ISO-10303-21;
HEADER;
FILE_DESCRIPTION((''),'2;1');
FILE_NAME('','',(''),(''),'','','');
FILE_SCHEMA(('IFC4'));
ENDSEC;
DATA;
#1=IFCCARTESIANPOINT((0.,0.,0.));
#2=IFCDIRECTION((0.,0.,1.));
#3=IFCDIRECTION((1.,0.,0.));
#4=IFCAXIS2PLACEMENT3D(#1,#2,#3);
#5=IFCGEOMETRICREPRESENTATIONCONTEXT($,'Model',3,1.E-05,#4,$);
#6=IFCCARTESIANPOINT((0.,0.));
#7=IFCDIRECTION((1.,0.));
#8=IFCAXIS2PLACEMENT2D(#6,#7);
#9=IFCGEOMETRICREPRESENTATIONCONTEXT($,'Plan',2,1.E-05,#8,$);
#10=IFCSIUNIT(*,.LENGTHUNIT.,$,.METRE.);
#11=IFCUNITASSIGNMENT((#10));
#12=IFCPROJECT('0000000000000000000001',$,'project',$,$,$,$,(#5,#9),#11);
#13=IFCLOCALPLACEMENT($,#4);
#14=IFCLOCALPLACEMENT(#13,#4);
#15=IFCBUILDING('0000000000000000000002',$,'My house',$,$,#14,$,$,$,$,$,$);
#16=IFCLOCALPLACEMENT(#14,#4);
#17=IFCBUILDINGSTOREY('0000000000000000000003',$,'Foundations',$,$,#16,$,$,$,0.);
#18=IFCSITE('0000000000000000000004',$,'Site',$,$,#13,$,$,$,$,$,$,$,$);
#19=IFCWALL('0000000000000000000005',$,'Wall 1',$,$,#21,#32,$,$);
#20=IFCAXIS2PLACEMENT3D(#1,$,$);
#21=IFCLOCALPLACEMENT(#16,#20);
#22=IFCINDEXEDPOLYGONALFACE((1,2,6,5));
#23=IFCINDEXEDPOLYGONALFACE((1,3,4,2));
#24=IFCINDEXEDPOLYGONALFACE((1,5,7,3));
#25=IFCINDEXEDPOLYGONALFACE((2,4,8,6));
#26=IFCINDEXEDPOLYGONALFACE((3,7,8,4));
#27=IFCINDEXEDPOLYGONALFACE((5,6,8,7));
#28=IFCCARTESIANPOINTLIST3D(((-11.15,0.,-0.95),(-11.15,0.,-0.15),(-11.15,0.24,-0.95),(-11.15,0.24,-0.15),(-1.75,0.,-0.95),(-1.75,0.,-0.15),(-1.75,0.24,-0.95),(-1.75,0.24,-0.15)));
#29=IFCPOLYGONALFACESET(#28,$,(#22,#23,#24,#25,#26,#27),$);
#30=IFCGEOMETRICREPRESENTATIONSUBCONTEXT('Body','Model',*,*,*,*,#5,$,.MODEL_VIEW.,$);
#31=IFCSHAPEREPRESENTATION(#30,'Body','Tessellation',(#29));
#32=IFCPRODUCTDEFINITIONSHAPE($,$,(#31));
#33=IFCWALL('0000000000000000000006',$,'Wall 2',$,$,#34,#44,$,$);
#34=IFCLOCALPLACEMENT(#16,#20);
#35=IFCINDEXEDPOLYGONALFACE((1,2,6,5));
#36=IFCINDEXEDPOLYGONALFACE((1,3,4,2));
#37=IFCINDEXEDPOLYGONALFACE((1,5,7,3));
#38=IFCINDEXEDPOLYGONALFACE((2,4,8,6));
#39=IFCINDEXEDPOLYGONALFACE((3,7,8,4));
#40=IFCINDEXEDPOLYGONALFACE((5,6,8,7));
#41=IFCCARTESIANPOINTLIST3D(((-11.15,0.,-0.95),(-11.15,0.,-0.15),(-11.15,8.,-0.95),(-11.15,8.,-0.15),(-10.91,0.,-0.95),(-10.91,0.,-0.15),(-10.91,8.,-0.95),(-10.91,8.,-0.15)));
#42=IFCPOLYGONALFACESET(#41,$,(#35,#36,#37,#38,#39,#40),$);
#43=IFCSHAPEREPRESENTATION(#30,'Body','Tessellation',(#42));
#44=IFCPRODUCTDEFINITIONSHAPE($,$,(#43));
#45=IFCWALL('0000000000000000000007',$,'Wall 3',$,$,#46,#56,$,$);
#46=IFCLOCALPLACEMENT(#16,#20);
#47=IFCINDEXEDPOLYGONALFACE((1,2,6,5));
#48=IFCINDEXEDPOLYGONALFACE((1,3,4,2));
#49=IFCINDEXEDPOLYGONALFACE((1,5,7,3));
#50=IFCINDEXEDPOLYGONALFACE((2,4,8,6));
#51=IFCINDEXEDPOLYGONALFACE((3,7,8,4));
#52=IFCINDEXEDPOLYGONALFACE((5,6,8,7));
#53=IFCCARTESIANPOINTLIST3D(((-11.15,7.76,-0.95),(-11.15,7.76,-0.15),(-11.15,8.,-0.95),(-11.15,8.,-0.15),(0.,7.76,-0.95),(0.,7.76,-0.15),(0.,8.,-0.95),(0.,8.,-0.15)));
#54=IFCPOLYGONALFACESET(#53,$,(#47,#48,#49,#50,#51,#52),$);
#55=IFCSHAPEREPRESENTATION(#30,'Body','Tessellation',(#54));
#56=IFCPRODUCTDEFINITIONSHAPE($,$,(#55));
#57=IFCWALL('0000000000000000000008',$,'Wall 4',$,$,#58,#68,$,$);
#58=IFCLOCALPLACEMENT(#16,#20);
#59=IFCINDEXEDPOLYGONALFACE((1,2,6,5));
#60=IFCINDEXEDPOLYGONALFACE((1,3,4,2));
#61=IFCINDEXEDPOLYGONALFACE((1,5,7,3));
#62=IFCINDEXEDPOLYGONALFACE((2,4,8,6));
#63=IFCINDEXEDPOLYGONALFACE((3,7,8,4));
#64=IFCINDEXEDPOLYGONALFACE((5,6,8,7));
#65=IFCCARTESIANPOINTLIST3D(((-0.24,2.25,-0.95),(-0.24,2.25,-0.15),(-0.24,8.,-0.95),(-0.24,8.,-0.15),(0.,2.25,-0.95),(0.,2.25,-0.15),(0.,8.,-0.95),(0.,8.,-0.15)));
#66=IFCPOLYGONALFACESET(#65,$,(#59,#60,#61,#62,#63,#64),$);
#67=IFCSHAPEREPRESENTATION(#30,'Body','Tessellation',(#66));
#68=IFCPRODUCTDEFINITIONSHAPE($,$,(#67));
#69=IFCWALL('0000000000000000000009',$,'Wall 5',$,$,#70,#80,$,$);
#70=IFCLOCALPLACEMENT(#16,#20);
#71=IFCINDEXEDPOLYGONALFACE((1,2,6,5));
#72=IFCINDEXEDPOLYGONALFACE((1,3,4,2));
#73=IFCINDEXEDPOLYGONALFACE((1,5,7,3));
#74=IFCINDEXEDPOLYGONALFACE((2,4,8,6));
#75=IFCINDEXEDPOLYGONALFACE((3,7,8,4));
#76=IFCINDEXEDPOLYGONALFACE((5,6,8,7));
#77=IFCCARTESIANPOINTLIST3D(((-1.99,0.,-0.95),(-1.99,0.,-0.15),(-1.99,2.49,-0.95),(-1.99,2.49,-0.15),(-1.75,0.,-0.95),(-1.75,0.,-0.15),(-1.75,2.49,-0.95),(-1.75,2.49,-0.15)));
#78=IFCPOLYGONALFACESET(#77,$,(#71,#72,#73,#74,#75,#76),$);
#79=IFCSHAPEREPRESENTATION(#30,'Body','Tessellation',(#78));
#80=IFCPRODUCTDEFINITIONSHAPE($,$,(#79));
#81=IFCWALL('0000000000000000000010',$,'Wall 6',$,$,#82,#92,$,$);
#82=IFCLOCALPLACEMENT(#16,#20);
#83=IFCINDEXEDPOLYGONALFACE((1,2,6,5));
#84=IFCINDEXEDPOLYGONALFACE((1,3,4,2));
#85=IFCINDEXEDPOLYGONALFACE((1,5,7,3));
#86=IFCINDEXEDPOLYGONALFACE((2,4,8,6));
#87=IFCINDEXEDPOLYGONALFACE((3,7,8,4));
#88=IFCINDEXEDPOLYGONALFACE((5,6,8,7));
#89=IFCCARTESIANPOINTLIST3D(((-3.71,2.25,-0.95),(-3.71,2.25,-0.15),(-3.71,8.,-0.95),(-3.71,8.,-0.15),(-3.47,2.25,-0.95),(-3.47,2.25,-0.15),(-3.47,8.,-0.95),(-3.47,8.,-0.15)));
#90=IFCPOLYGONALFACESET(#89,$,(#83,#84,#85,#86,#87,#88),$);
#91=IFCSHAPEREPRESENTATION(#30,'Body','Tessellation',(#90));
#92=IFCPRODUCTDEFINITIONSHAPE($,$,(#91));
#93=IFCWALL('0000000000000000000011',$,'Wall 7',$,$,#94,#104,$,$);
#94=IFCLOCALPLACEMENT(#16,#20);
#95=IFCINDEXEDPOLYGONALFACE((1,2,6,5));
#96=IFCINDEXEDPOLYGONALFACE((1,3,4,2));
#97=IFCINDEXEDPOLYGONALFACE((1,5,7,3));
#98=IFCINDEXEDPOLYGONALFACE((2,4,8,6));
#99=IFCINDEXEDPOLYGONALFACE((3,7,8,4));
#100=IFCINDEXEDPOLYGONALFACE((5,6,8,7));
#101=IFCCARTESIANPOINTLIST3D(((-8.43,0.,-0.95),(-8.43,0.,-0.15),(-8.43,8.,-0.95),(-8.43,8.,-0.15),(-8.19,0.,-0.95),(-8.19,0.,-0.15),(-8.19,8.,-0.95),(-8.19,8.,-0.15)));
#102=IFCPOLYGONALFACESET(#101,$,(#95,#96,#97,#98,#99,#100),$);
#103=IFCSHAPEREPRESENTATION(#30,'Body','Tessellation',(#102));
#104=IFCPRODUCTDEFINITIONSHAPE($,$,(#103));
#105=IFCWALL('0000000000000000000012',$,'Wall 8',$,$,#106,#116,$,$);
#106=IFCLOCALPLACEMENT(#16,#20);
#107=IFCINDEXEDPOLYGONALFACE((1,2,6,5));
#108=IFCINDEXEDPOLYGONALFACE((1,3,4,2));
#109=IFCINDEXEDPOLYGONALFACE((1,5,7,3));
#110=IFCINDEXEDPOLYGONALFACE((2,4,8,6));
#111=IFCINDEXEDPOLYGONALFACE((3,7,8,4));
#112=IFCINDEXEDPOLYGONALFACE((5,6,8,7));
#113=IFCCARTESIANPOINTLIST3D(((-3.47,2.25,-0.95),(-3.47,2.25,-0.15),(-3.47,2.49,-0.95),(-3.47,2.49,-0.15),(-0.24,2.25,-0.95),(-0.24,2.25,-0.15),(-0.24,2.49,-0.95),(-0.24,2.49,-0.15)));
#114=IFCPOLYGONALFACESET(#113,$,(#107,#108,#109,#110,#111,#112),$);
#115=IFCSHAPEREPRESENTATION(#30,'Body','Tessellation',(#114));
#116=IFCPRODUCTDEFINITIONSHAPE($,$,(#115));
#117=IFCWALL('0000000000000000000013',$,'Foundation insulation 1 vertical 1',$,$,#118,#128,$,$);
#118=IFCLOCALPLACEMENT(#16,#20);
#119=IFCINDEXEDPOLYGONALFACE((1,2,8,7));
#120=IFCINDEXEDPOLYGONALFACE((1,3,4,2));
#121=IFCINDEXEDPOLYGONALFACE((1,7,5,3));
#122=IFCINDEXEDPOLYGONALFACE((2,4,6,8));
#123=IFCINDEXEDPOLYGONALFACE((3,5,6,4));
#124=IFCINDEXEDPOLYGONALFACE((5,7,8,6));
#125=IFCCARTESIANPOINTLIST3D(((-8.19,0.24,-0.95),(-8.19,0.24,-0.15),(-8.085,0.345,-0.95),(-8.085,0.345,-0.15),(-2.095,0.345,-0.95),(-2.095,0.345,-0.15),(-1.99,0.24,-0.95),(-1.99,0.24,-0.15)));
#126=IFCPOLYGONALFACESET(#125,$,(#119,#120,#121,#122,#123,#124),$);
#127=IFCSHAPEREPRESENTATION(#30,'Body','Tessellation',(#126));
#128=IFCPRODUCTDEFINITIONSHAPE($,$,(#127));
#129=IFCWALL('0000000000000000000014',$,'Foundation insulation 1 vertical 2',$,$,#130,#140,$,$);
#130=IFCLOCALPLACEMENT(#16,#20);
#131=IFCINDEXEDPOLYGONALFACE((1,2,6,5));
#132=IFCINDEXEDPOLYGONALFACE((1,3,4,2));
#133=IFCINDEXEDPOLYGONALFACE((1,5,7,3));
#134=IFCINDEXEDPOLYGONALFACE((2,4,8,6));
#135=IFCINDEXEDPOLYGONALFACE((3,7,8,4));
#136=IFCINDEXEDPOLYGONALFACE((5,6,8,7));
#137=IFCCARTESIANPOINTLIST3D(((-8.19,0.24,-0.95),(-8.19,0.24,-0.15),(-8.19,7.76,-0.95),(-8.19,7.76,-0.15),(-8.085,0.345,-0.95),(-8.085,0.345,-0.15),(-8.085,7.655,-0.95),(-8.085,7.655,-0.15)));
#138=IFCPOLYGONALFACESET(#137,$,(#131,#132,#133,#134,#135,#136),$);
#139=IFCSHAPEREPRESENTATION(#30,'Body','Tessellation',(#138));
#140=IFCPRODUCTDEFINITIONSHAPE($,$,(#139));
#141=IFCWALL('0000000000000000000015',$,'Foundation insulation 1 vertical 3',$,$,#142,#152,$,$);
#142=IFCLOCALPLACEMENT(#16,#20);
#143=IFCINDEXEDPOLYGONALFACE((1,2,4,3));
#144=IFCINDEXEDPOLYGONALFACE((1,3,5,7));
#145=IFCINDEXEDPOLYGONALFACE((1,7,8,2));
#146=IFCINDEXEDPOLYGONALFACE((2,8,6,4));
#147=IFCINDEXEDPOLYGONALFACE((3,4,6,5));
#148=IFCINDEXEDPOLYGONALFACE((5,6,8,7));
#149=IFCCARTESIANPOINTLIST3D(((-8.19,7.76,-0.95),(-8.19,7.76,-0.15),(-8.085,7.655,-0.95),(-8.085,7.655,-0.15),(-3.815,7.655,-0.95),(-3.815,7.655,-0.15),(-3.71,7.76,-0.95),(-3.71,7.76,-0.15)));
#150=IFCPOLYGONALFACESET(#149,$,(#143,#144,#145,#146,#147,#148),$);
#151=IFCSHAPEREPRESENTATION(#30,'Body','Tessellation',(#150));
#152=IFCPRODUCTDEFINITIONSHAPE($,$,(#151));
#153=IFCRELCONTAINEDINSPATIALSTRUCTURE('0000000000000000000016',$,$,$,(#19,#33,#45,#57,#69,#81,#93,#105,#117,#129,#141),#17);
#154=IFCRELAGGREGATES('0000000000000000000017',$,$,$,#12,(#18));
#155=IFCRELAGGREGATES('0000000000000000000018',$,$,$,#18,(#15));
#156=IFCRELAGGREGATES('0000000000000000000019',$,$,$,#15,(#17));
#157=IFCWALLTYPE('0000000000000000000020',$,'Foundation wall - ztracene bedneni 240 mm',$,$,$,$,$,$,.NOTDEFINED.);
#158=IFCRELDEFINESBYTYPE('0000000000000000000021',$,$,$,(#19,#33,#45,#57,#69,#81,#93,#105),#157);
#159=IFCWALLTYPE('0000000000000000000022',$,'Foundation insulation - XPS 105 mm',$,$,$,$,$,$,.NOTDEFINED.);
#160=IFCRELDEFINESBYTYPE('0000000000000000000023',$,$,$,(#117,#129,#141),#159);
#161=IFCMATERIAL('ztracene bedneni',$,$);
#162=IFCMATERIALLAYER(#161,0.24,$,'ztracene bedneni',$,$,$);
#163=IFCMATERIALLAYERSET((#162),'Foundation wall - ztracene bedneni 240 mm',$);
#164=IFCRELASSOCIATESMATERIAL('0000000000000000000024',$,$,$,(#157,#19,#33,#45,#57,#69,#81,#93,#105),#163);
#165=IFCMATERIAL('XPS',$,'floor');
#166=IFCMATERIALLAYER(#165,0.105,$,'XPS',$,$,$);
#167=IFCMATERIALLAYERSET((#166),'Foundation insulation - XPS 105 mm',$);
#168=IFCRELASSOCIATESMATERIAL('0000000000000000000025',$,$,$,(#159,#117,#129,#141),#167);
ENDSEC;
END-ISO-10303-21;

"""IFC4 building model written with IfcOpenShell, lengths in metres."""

from ifc_helpers import new_model, si_unit, frame, origin_with_axes, origin_2d_with_axis, place, context, subcontext, project, spatial, line, indexed_curve, outline, extrude, source, transform, mapped, material, layer, layer_set, layer_usage, type_object, element, save


model = new_model("IFC4")

# Units and contexts
model_context = context("Model", 3, precision=1e-05, world=origin_with_axes())
plan_context = context("Plan", 2, precision=1e-05, world=origin_2d_with_axis())
body_context = subcontext(model_context, "Body", "Model", "MODEL_VIEW")
ifc_project = project(units=[si_unit("LENGTHUNIT", "METRE")], contexts=[model_context, plan_context])

# Site, building, storey
site_placement = place(None, origin_with_axes())
site = spatial("IfcSite", under=ifc_project, at=site_placement, Name="Site")
building_placement = place(site_placement, origin_with_axes())
building = spatial("IfcBuilding", under=site, at=building_placement, Name="My house")
storey_placement = place(building_placement, origin_with_axes())
storey = spatial("IfcBuildingStorey", under=building, at=storey_placement, Name="Foundations", Elevation=0.0)

# Shared definitions
ifc_material_1 = material(Name="XPS", Category="floor")

# Walls
ifc_material_2 = material(Name="ztracene bedneni")
ifc_layer_1 = layer(ifc_material_2, 0.24, Name="ztracene bedneni")
ifc_layer_set_1 = layer_set([ifc_layer_1], Name="Foundation wall - ztracene bedneni 240 mm")
ifc_layer_usage_1 = layer_usage(ifc_layer_set_1, "AXIS2", "NEGATIVE", 0.24)
wall_type_1 = type_object("IfcWallType", Name="Foundation wall - ztracene bedneni 240 mm", PredefinedType="NOTDEFINED", material=ifc_layer_set_1)
shared_shape_1 = source(origin_with_axes(), body_context, "Body", "SweptSolid", [
    extrude(outline(indexed_curve([(0.0, 0.0), (0.0, 0.24), (9.4, 0.24), (9.4, 0.0), (0.0, 0.0)], self_intersect=False)), origin_with_axes(), (0.0, 0.0, 1.0), 0.8),
])
wall_1_placement = place(storey_placement, frame((-1.75, 0.0, -0.95), z_axis=(0.0, 0.0, 1.0), x_axis=(1.0, 0.0, 0.0)))
element("IfcWall", 1, at=wall_1_placement, inside=storey, type_object=wall_type_1, material=ifc_layer_usage_1, Name="Wall 1", context=body_context, shape_type="MappedRepresentation", body=[
    mapped(shared_shape_1, transform((0.0, 0.0, 0.0), x_axis=(-1.0, 0.0, 0.0), y_axis=(0.0, 1.0, 0.0), z_axis=(0.0, 0.0, 1.0), scale=1.0)),
])
ifc_layer_usage_2 = layer_usage(ifc_layer_set_1, "AXIS2", "NEGATIVE", 0.24)
shared_shape_2 = source(origin_with_axes(), body_context, "Body", "SweptSolid", [
    extrude(outline(indexed_curve([(0.0, 0.0), (0.0, 0.24), (8.0, 0.24), (8.0, 0.0), (0.0, 0.0)], self_intersect=False)), origin_with_axes(), (0.0, 0.0, 1.0), 0.8),
])
wall_2_placement = place(storey_placement, frame((-11.15, 0.0, -0.95), z_axis=(0.0, 0.0, 1.0), x_axis=(0.0, -1.0, 0.0)))
element("IfcWall", 2, at=wall_2_placement, inside=storey, type_object=wall_type_1, material=ifc_layer_usage_2, Name="Wall 2", context=body_context, shape_type="MappedRepresentation", body=[
    mapped(shared_shape_2, transform((0.0, 0.0, 0.0), x_axis=(-1.0, 0.0, 0.0), y_axis=(0.0, 1.0, 0.0), z_axis=(0.0, 0.0, 1.0), scale=1.0)),
])
ifc_layer_usage_3 = layer_usage(ifc_layer_set_1, "AXIS2", "NEGATIVE", 0.24)
shared_shape_3 = source(origin_with_axes(), body_context, "Body", "SweptSolid", [
    extrude(outline(indexed_curve([(0.0, 0.0), (0.0, 0.24), (11.15, 0.24), (11.15, 0.0), (0.0, 0.0)], self_intersect=False)), origin_with_axes(), (0.0, 0.0, 1.0), 0.8),
])
wall_3_placement = place(storey_placement, frame((-11.15, 8.0, -0.95), z_axis=(0.0, 0.0, 1.0), x_axis=(-1.0, 0.0, 0.0)))
element("IfcWall", 3, at=wall_3_placement, inside=storey, type_object=wall_type_1, material=ifc_layer_usage_3, Name="Wall 3", context=body_context, shape_type="MappedRepresentation", body=[
    mapped(shared_shape_3, transform((0.0, 0.0, 0.0), x_axis=(-1.0, 0.0, 0.0), y_axis=(0.0, 1.0, 0.0), z_axis=(0.0, 0.0, 1.0), scale=1.0)),
])
ifc_layer_usage_4 = layer_usage(ifc_layer_set_1, "AXIS2", "NEGATIVE", 0.24)
shared_shape_4 = source(origin_with_axes(), body_context, "Body", "SweptSolid", [
    extrude(outline(indexed_curve([(0.0, 0.0), (0.0, 0.24), (5.75, 0.24), (5.75, 0.0), (0.0, 0.0)], self_intersect=False)), origin_with_axes(), (0.0, 0.0, 1.0), 0.8),
])
wall_4_placement = place(storey_placement, frame((0.0, 8.0, -0.95), z_axis=(0.0, 0.0, 1.0), x_axis=(0.0, 1.0, 0.0)))
element("IfcWall", 4, at=wall_4_placement, inside=storey, type_object=wall_type_1, material=ifc_layer_usage_4, Name="Wall 4", context=body_context, shape_type="MappedRepresentation", body=[
    mapped(shared_shape_4, transform((0.0, 0.0, 0.0), x_axis=(-1.0, 0.0, 0.0), y_axis=(0.0, 1.0, 0.0), z_axis=(0.0, 0.0, 1.0), scale=1.0)),
])
ifc_layer_usage_5 = layer_usage(ifc_layer_set_1, "AXIS2", "NEGATIVE", 0.24)
shared_shape_5 = source(origin_with_axes(), body_context, "Body", "SweptSolid", [
    extrude(outline(indexed_curve([(0.0, 0.0), (0.0, 0.24), (2.49, 0.24), (2.49, 0.0), (0.0, 0.0)], self_intersect=False)), origin_with_axes(), (0.0, 0.0, 1.0), 0.8),
])
wall_5_placement = place(storey_placement, frame((-1.75, 2.49, -0.95), z_axis=(0.0, 0.0, 1.0), x_axis=(0.0, 1.0, 0.0)))
element("IfcWall", 5, at=wall_5_placement, inside=storey, type_object=wall_type_1, material=ifc_layer_usage_5, Name="Wall 5", context=body_context, shape_type="MappedRepresentation", body=[
    mapped(shared_shape_5, transform((0.0, 0.0, 0.0), x_axis=(-1.0, 0.0, 0.0), y_axis=(0.0, 1.0, 0.0), z_axis=(0.0, 0.0, 1.0), scale=1.0)),
])
ifc_layer_usage_6 = layer_usage(ifc_layer_set_1, "AXIS2", "NEGATIVE", 0.24)
shared_shape_6 = source(origin_with_axes(), body_context, "Body", "SweptSolid", [
    extrude(outline(indexed_curve([(0.0, 0.0), (0.0, 0.24), (5.75, 0.24), (5.75, 0.0), (0.0, 0.0)], self_intersect=False)), origin_with_axes(), (0.0, 0.0, 1.0), 0.8),
])
wall_6_placement = place(storey_placement, frame((-3.71, 2.25, -0.95), z_axis=(0.0, 0.0, 1.0), x_axis=(0.0, -1.0, 0.0)))
element("IfcWall", 6, at=wall_6_placement, inside=storey, type_object=wall_type_1, material=ifc_layer_usage_6, Name="Wall 6", context=body_context, shape_type="MappedRepresentation", body=[
    mapped(shared_shape_6, transform((0.0, 0.0, 0.0), x_axis=(-1.0, 0.0, 0.0), y_axis=(0.0, 1.0, 0.0), z_axis=(0.0, 0.0, 1.0), scale=1.0)),
])
ifc_layer_usage_7 = layer_usage(ifc_layer_set_1, "AXIS2", "NEGATIVE", 0.24)
shared_shape_7 = source(origin_with_axes(), body_context, "Body", "SweptSolid", [
    extrude(outline(indexed_curve([(0.0, 0.0), (0.0, 0.24), (8.0, 0.24), (8.0, 0.0), (0.0, 0.0)], self_intersect=False)), origin_with_axes(), (0.0, 0.0, 1.0), 0.8),
])
wall_7_placement = place(storey_placement, frame((-8.43, 0.0, -0.95), z_axis=(0.0, 0.0, 1.0), x_axis=(0.0, -1.0, 0.0)))
element("IfcWall", 7, at=wall_7_placement, inside=storey, type_object=wall_type_1, material=ifc_layer_usage_7, Name="Wall 7", context=body_context, shape_type="MappedRepresentation", body=[
    mapped(shared_shape_7, transform((0.0, 0.0, 0.0), x_axis=(-1.0, 0.0, 0.0), y_axis=(0.0, 1.0, 0.0), z_axis=(0.0, 0.0, 1.0), scale=1.0)),
])
ifc_layer_usage_8 = layer_usage(ifc_layer_set_1, "AXIS2", "NEGATIVE", 0.24)
shared_shape_8 = source(origin_with_axes(), body_context, "Body", "SweptSolid", [
    extrude(outline(indexed_curve([(0.0, 0.0), (0.0, 0.24), (3.23, 0.24), (3.23, 0.0), (0.0, 0.0)], self_intersect=False)), origin_with_axes(), (0.0, 0.0, 1.0), 0.8),
])
wall_8_placement = place(storey_placement, frame((-0.24, 2.25, -0.95), z_axis=(0.0, 0.0, 1.0), x_axis=(1.0, 0.0, 0.0)))
element("IfcWall", 8, at=wall_8_placement, inside=storey, type_object=wall_type_1, material=ifc_layer_usage_8, Name="Wall 8", context=body_context, shape_type="MappedRepresentation", body=[
    mapped(shared_shape_8, transform((0.0, 0.0, 0.0), x_axis=(-1.0, 0.0, 0.0), y_axis=(0.0, 1.0, 0.0), z_axis=(0.0, 0.0, 1.0), scale=1.0)),
])
ifc_layer_2 = layer(ifc_material_1, 0.105, Name="XPS")
ifc_layer_set_2 = layer_set([ifc_layer_2], Name="Foundation insulation - XPS 105 mm")
ifc_layer_usage_9 = layer_usage(ifc_layer_set_2, "AXIS2", "NEGATIVE", 0.105)
wall_type_2 = type_object("IfcWallType", Name="Foundation insulation - XPS 105 mm", PredefinedType="NOTDEFINED", material=ifc_layer_set_2)
shared_shape_9 = source(origin_with_axes(), body_context, "Body", "SweptSolid", [
    extrude(outline(indexed_curve([(0.0, 0.0), (0.105, 0.105), (6.095, 0.105), (6.2, 0.0)], segments=[line(1, 2, 3, 4, 1)])), origin_with_axes(), (0.0, 0.0, 1.0), 0.8),
])
wall_9_placement = place(storey_placement, frame((-1.99, 0.24, -0.95), z_axis=(0.0, 0.0, 1.0), x_axis=(1.0, 0.0, 0.0)))
element("IfcWall", 9, at=wall_9_placement, inside=storey, type_object=wall_type_2, material=ifc_layer_usage_9, Name="Foundation insulation 1 vertical 1", context=body_context, shape_type="MappedRepresentation", body=[
    mapped(shared_shape_9, transform((0.0, 0.0, 0.0), x_axis=(-1.0, 0.0, 0.0), y_axis=(0.0, 1.0, 0.0), z_axis=(0.0, 0.0, 1.0), scale=1.0)),
])
ifc_layer_usage_10 = layer_usage(ifc_layer_set_2, "AXIS2", "NEGATIVE", 0.105)
shared_shape_10 = source(origin_with_axes(), body_context, "Body", "SweptSolid", [
    extrude(outline(indexed_curve([(0.0, 0.0), (0.105, 0.105), (7.415, 0.105), (7.52, 0.0)], segments=[line(1, 2, 3, 4, 1)])), origin_with_axes(), (0.0, 0.0, 1.0), 0.8),
])
wall_10_placement = place(storey_placement, frame((-8.19, 0.24, -0.95), z_axis=(0.0, 0.0, 1.0), x_axis=(0.0, -1.0, 0.0)))
element("IfcWall", 10, at=wall_10_placement, inside=storey, type_object=wall_type_2, material=ifc_layer_usage_10, Name="Foundation insulation 1 vertical 2", context=body_context, shape_type="MappedRepresentation", body=[
    mapped(shared_shape_10, transform((0.0, 0.0, 0.0), x_axis=(-1.0, 0.0, 0.0), y_axis=(0.0, 1.0, 0.0), z_axis=(0.0, 0.0, 1.0), scale=1.0)),
])
ifc_layer_usage_11 = layer_usage(ifc_layer_set_2, "AXIS2", "NEGATIVE", 0.105)
shared_shape_11 = source(origin_with_axes(), body_context, "Body", "SweptSolid", [
    extrude(outline(indexed_curve([(0.0, 0.0), (0.105, 0.105), (4.375, 0.105), (4.48, 0.0)], segments=[line(1, 2, 3, 4, 1)])), origin_with_axes(), (0.0, 0.0, 1.0), 0.8),
])
wall_11_placement = place(storey_placement, frame((-8.19, 7.76, -0.95), z_axis=(0.0, 0.0, 1.0), x_axis=(-1.0, 0.0, 0.0)))
element("IfcWall", 11, at=wall_11_placement, inside=storey, type_object=wall_type_2, material=ifc_layer_usage_11, Name="Foundation insulation 1 vertical 3", context=body_context, shape_type="MappedRepresentation", body=[
    mapped(shared_shape_11, transform((0.0, 0.0, 0.0), x_axis=(-1.0, 0.0, 0.0), y_axis=(0.0, 1.0, 0.0), z_axis=(0.0, 0.0, 1.0), scale=1.0)),
])

save(model, "model.ifc")
